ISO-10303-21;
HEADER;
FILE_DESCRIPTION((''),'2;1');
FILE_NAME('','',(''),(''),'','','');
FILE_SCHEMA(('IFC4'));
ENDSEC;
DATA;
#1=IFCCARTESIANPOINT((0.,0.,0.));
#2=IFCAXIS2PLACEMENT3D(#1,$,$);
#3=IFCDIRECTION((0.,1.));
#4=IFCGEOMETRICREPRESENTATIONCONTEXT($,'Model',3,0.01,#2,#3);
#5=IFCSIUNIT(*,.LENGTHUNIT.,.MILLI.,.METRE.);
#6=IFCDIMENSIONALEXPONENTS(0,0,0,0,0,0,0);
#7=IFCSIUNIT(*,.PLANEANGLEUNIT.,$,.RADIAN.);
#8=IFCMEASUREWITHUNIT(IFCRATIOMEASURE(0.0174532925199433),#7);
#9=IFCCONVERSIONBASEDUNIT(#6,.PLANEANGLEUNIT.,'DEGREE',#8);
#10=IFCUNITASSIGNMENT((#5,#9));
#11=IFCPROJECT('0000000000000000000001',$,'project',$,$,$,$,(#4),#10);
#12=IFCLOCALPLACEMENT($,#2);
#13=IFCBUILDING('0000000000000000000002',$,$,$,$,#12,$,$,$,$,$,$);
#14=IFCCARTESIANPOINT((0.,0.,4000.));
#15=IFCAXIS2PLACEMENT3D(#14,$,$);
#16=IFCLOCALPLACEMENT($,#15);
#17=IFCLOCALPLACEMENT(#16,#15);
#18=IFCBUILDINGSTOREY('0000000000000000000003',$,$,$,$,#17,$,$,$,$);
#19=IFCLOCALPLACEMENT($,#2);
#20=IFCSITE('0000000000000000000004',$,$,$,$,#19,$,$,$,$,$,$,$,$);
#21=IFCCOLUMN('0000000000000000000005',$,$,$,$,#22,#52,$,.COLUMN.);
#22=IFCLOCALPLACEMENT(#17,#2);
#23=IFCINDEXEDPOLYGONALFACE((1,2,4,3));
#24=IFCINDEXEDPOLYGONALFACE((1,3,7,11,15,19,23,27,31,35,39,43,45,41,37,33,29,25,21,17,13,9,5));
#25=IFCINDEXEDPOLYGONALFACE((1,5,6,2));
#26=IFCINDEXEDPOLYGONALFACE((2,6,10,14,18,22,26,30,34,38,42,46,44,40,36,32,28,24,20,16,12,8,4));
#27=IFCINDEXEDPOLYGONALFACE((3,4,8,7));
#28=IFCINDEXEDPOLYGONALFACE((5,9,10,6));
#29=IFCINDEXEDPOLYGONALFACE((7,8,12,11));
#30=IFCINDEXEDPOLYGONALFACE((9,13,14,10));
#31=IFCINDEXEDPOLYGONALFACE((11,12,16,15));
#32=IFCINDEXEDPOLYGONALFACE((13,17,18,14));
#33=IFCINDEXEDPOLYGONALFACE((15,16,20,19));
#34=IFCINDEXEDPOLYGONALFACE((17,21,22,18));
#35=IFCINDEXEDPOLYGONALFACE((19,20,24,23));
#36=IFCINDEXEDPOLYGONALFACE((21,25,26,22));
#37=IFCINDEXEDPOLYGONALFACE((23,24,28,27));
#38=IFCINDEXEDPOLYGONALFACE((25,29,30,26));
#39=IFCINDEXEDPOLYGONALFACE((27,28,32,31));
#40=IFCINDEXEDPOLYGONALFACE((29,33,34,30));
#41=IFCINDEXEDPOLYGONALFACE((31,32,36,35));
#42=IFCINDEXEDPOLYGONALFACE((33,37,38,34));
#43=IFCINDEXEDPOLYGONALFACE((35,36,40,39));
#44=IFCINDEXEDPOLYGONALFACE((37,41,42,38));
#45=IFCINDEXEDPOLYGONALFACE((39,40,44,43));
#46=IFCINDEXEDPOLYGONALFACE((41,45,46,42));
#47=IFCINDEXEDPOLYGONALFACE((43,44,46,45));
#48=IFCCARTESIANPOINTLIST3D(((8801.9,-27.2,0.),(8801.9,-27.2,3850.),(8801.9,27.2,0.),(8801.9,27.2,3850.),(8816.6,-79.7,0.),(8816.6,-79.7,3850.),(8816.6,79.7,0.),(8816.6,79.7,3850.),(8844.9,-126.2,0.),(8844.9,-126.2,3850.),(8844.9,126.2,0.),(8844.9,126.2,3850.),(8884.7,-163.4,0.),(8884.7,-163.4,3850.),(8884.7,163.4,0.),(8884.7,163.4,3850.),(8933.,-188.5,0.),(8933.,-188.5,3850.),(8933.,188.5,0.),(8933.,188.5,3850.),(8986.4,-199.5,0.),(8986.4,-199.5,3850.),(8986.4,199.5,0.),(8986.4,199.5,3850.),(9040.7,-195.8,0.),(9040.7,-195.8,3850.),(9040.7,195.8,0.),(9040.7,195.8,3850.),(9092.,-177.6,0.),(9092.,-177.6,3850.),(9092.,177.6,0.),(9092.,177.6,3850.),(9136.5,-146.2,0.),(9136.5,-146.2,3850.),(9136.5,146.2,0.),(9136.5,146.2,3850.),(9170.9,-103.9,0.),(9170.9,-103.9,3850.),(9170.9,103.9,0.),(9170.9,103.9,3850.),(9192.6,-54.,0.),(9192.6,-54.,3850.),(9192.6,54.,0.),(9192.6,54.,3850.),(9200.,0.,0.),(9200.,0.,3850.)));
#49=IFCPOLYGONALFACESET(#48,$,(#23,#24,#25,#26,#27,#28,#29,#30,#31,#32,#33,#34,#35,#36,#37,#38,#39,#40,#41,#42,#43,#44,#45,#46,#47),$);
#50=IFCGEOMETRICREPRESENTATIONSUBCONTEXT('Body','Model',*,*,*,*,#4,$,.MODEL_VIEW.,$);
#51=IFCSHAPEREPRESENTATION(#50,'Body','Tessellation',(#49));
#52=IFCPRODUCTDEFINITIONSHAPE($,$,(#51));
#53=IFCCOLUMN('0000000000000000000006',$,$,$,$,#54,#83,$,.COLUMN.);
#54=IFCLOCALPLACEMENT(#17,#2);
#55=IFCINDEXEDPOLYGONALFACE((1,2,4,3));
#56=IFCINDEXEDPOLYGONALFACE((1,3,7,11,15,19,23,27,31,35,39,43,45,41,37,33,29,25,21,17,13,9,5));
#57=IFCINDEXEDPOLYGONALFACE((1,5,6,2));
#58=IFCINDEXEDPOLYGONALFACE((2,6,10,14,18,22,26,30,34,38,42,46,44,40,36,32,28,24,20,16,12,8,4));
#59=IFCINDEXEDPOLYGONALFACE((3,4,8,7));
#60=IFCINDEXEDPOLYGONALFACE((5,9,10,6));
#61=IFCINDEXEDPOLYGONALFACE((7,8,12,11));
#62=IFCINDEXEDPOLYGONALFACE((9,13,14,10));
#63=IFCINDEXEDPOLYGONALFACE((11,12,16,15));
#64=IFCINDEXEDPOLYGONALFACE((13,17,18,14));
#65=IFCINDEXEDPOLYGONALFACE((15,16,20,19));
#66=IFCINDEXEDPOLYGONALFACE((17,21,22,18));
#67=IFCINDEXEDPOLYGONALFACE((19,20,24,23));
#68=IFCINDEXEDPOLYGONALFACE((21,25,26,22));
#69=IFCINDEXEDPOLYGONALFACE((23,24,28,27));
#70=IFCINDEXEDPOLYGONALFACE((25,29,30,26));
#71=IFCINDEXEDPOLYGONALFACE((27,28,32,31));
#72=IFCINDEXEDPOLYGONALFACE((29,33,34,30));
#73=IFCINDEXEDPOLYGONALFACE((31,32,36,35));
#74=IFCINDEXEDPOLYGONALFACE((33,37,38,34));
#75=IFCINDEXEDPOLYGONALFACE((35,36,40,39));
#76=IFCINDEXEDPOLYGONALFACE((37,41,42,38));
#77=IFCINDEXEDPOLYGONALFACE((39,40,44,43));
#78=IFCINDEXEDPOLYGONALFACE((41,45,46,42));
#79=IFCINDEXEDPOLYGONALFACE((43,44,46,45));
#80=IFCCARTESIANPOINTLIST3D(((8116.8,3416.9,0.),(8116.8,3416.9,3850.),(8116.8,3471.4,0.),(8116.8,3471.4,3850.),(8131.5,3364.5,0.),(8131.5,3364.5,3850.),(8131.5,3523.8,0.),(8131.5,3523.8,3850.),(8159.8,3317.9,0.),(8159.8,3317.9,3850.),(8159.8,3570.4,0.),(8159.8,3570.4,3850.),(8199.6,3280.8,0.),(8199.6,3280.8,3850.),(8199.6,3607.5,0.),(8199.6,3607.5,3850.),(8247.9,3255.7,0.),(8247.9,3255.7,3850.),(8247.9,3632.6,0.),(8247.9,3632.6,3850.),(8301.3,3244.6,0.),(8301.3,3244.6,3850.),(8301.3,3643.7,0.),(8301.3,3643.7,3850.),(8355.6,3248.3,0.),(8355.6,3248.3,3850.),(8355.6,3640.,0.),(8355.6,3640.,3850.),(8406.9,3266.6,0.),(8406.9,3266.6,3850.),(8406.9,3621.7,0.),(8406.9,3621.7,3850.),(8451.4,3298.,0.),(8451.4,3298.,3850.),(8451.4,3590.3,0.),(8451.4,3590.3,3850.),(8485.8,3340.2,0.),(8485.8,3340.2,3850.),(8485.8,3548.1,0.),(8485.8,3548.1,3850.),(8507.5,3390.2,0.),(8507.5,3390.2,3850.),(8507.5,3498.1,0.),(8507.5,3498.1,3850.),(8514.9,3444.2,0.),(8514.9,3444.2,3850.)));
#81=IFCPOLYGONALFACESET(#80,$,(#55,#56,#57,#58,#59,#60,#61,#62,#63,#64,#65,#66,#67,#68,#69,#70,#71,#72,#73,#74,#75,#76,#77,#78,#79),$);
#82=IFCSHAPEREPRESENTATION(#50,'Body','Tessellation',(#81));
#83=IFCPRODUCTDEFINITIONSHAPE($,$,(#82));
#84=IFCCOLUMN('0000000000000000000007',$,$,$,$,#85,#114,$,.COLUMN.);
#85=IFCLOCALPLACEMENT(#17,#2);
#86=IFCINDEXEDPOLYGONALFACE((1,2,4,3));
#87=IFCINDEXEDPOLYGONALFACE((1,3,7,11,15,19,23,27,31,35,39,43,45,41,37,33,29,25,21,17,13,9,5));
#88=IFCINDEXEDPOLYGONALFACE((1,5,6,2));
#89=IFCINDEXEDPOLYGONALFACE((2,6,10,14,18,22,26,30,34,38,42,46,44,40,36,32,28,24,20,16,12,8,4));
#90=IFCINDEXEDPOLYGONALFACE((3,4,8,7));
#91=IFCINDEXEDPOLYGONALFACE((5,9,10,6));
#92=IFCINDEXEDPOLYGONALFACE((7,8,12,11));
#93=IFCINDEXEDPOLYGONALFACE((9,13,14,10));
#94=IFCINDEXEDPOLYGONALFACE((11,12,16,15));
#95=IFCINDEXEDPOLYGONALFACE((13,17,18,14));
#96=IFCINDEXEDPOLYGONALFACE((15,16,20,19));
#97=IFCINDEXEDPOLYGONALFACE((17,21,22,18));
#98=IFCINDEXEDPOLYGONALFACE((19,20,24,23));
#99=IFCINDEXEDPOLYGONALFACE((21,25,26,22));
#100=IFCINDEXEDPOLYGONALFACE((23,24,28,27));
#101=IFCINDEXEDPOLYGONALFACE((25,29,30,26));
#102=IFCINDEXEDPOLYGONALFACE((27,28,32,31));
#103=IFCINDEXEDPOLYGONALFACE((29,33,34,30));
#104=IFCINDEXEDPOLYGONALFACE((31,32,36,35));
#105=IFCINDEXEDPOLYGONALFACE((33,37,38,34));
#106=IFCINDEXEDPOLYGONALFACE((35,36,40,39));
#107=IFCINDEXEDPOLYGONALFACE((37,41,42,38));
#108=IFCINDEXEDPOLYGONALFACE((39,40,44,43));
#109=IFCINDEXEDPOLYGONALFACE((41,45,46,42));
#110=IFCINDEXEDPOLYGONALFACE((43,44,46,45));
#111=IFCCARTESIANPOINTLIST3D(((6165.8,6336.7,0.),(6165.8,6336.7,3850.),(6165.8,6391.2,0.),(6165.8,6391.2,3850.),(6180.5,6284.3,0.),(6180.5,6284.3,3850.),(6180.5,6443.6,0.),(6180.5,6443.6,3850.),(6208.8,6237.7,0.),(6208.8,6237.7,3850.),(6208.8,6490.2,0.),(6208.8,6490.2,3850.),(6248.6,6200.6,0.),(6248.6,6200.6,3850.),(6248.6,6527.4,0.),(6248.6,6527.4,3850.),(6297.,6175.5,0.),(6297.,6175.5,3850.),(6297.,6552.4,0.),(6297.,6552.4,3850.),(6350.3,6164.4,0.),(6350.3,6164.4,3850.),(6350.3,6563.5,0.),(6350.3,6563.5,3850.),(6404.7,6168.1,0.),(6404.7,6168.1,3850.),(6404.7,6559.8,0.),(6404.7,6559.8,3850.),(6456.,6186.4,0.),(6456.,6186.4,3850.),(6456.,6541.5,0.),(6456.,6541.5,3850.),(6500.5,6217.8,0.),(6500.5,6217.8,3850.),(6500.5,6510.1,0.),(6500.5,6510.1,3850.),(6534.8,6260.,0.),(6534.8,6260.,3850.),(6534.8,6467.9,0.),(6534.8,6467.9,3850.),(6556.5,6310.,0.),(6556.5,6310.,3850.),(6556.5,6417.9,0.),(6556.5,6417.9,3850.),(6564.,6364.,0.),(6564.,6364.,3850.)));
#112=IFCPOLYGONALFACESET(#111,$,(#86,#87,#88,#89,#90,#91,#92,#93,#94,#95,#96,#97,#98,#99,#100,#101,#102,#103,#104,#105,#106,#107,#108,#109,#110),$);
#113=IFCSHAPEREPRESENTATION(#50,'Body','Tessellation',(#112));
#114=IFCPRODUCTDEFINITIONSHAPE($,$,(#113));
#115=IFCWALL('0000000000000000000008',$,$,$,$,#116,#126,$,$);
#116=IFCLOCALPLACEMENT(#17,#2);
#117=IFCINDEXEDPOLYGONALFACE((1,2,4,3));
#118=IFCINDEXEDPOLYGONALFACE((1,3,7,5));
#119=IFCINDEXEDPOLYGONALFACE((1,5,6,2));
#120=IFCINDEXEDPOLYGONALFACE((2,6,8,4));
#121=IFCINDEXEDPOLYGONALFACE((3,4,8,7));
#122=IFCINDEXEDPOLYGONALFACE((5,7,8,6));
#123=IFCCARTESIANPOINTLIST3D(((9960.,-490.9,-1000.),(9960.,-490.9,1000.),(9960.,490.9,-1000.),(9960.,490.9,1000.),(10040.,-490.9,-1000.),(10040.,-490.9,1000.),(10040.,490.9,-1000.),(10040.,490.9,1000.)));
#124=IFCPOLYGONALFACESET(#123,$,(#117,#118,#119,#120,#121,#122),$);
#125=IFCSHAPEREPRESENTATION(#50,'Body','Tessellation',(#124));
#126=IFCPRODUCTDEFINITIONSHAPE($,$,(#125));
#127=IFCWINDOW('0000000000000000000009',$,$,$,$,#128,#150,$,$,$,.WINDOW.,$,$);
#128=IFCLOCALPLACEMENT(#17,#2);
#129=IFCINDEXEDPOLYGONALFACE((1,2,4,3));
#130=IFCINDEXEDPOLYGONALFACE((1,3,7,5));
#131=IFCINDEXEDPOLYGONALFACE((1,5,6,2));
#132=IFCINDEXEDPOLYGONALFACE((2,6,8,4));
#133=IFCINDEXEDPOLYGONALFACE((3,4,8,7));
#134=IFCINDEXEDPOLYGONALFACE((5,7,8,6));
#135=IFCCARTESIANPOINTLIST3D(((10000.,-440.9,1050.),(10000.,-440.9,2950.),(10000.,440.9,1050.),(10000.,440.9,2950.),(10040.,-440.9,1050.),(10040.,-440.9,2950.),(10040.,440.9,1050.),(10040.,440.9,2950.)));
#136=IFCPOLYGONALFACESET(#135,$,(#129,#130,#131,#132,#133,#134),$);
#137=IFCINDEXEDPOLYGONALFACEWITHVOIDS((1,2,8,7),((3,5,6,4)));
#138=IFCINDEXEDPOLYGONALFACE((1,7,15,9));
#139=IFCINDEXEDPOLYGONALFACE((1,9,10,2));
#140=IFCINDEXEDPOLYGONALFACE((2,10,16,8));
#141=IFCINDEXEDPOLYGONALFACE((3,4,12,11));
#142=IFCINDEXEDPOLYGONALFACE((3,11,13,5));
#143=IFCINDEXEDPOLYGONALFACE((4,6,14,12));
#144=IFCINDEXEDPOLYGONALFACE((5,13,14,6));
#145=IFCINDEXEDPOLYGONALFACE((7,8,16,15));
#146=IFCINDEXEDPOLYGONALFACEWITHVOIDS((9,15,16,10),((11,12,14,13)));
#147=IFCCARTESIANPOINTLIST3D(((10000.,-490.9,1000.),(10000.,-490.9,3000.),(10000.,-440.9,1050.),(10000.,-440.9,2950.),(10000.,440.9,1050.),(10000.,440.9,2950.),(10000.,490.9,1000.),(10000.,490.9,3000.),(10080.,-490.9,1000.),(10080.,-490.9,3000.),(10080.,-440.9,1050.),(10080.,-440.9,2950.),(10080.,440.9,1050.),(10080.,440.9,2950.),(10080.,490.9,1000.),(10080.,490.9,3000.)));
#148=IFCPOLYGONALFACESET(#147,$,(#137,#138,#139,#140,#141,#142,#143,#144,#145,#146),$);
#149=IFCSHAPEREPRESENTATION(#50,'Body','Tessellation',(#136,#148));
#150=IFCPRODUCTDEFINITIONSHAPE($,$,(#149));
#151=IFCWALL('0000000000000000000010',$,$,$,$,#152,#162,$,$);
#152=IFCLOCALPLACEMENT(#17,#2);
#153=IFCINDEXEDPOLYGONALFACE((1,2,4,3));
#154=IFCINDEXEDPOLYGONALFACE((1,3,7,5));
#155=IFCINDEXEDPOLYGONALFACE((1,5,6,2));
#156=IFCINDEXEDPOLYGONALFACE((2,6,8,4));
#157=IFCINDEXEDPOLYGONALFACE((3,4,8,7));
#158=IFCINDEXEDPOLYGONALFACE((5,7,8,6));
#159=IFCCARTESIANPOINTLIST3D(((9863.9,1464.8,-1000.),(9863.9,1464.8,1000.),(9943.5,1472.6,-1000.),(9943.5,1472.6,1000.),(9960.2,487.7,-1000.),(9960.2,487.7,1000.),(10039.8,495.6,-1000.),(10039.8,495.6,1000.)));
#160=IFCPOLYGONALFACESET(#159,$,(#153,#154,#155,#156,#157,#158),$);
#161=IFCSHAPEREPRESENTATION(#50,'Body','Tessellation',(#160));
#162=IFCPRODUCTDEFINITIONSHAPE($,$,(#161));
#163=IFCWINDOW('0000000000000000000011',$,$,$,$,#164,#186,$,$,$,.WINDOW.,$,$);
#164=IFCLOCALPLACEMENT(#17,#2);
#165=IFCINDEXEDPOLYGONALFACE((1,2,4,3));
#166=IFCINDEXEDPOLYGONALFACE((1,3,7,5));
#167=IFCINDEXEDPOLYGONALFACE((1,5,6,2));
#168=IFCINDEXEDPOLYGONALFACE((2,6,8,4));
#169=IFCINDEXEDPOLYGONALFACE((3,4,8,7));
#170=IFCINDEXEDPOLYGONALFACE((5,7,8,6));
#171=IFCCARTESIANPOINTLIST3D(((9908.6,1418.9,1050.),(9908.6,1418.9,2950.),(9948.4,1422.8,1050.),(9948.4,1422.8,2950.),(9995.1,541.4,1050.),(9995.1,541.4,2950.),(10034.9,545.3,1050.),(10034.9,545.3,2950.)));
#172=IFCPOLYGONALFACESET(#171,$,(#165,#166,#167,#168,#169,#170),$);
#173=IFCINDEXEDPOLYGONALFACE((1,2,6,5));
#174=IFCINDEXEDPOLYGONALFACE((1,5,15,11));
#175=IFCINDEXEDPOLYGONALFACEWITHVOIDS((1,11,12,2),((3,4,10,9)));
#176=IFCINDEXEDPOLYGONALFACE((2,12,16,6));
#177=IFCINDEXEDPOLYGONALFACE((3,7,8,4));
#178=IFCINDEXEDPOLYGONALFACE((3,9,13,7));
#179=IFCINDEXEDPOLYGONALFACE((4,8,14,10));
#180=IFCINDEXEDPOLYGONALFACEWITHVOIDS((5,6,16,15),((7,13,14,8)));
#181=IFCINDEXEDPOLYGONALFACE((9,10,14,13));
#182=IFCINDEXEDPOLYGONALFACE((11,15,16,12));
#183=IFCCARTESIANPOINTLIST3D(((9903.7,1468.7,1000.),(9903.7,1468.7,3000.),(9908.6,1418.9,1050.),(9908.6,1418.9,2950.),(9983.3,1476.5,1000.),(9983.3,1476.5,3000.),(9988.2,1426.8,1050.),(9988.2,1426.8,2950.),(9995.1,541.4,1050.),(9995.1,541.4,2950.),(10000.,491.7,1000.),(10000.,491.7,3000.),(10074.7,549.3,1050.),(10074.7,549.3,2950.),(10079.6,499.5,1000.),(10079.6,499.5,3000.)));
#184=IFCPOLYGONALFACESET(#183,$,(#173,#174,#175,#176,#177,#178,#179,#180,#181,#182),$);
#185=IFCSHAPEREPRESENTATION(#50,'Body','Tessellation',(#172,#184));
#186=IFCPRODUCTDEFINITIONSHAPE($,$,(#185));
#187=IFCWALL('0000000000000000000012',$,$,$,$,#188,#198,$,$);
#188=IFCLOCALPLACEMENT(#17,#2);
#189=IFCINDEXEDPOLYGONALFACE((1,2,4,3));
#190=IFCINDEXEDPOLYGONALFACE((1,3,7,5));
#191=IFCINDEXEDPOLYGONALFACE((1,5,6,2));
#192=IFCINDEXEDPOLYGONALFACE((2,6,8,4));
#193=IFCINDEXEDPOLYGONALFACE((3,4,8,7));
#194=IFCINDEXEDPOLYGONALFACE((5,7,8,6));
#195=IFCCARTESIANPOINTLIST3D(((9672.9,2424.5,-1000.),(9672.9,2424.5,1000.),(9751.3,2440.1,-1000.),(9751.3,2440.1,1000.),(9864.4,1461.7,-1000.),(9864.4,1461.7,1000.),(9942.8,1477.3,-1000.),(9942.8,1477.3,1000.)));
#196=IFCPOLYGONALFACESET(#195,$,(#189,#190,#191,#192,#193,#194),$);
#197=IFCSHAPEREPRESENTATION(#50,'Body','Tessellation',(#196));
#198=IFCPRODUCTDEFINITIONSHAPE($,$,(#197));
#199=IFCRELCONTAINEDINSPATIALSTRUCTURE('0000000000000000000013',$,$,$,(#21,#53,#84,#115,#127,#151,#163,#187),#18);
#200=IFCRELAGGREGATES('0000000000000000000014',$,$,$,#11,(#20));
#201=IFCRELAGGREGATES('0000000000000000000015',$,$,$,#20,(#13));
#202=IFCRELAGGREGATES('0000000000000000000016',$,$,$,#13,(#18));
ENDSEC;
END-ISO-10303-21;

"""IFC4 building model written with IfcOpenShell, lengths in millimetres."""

from ifc_helpers import new_model, entity, si_unit, converted_unit, direction, frame, origin, origin_2d, place, context, subcontext, project, spatial, rectangle, circle, extrude, element, save


model = new_model("IFC4")

# Units and contexts
model_context = context("Model", 3, precision=0.01, world=origin(), true_north=direction((0.0, 1.0)))
body_context = subcontext(model_context, "Body", "Model", "MODEL_VIEW")
ifc_project = project(units=[si_unit("LENGTHUNIT", "METRE", prefix="MILLI"), converted_unit("PLANEANGLEUNIT", "DEGREE", entity("IfcRatioMeasure", 0.0174532925199433), si_unit("PLANEANGLEUNIT", "RADIAN"), dimensions=[0, 0, 0, 0, 0, 0, 0])], contexts=[model_context])

# Site, building, storey
site_placement = place(None, origin())
site = spatial("IfcSite", under=ifc_project, at=site_placement)
building_placement = place(None, origin())
building = spatial("IfcBuilding", under=site, at=building_placement)
placement = place(None, frame((0.0, 0.0, 4000.0)))
storey_placement = place(placement, frame((0.0, 0.0, 4000.0)))
storey = spatial("IfcBuildingStorey", under=building, at=storey_placement)

# Columns
for number, where in (
    (1, (9000.0, 0.0, 0.0)),
    (2, (8314.9, 3444.2, 0.0)),
    (3, (6364.0, 6364.0, 0.0)),
):
    element("IfcColumn", number, at=place(storey_placement, frame(where)), inside=storey, PredefinedType="COLUMN", context=body_context, shape_type="SweptSolid", body=[
        extrude(circle(Radius=200.0, at=origin_2d()), origin(), (0.0, 0.0, 1.0), 3850.0),
    ])

# Wall
wall_1_placement = place(storey_placement, frame((10000.0, 0.0, -1000.0), z_axis=(0.0, 0.0, 1.0), x_axis=(0.0, 10000.0, 0.0)))
element("IfcWall", 4, at=wall_1_placement, inside=storey, context=body_context, shape_type="SweptSolid", body=[
    extrude(rectangle(XDim=981.7, YDim=80.0, at=origin_2d()), origin(), (0.0, 0.0, 1.0), 2000.0),
])

# Window
cartesian_point_1 = entity("IfcCartesianPoint", [-440.9, -950.0])
shared_polyline = entity("IfcPolyline", [cartesian_point_1, entity("IfcCartesianPoint", [-440.9, 950.0]), entity("IfcCartesianPoint", [-440.9, 950.0]), entity("IfcCartesianPoint", [440.9, 950.0]), entity("IfcCartesianPoint", [440.9, 950.0]), entity("IfcCartesianPoint", [440.9, -950.0]), entity("IfcCartesianPoint", [440.9, -950.0]), entity("IfcCartesianPoint", [-440.9, -950.0]), cartesian_point_1])
window_1_placement = place(storey_placement, frame((10000.0, 0.0, 2000.0), z_axis=(0.0, 0.0, 1.0), x_axis=(0.0, 10000.0, 0.0)))
cartesian_point_2 = entity("IfcCartesianPoint", [-490.9, -1000.0])
element("IfcWindow", 5, at=window_1_placement, inside=storey, PredefinedType="WINDOW", context=body_context, shape_type="SweptSolid", body=[
    entity("IfcExtrudedAreaSolid", entity("IfcArbitraryClosedProfileDef", "AREA", None, shared_polyline), entity("IfcAxis2Placement3D", entity("IfcCartesianPoint", [0.0, 0.0, 0.0]), entity("IfcDirection", [0.0, -1.0, 0.0]), entity("IfcDirection", [1.0, 0.0, 0.0])), entity("IfcDirection", [0.0, 0.0, 1.0]), 40.0),
    entity("IfcExtrudedAreaSolid", entity("IfcArbitraryProfileDefWithVoids", "AREA", None, entity("IfcPolyline", [cartesian_point_2, entity("IfcCartesianPoint", [-490.9, 1000.0]), entity("IfcCartesianPoint", [-490.9, 1000.0]), entity("IfcCartesianPoint", [490.9, 1000.0]), entity("IfcCartesianPoint", [490.9, 1000.0]), entity("IfcCartesianPoint", [490.9, -1000.0]), entity("IfcCartesianPoint", [490.9, -1000.0]), entity("IfcCartesianPoint", [-490.9, -1000.0]), cartesian_point_2]), [shared_polyline]), entity("IfcAxis2Placement3D", entity("IfcCartesianPoint", [0.0, 0.0, 0.0]), entity("IfcDirection", [0.0, -1.0, 0.0]), entity("IfcDirection", [1.0, 0.0, 0.0])), entity("IfcDirection", [0.0, 0.0, 1.0]), 80.0),
])

# Wall
wall_2_placement = place(storey_placement, frame((9951.8, 980.2, -1000.0), z_axis=(0.0, 0.0, 1.0), x_axis=(-980.17143, 9951.847264, 0.0)))
element("IfcWall", 6, at=wall_2_placement, inside=storey, context=body_context, shape_type="SweptSolid", body=[
    extrude(rectangle(XDim=981.7, YDim=80.0, at=origin_2d()), origin(), (0.0, 0.0, 1.0), 2000.0),
])

# Window
window_2_placement = place(storey_placement, frame((9951.8, 980.2, 2000.0), z_axis=(0.0, 0.0, 1.0), x_axis=(-980.17143, 9951.847264, 0.0)))
cartesian_point_3 = entity("IfcCartesianPoint", [-490.9, -1000.0])
element("IfcWindow", 7, at=window_2_placement, inside=storey, PredefinedType="WINDOW", context=body_context, shape_type="SweptSolid", body=[
    entity("IfcExtrudedAreaSolid", entity("IfcArbitraryClosedProfileDef", "AREA", None, shared_polyline), entity("IfcAxis2Placement3D", entity("IfcCartesianPoint", [0.0, 0.0, 0.0]), entity("IfcDirection", [0.0, -1.0, 0.0]), entity("IfcDirection", [1.0, 0.0, 0.0])), entity("IfcDirection", [0.0, 0.0, 1.0]), 40.0),
    entity("IfcExtrudedAreaSolid", entity("IfcArbitraryProfileDefWithVoids", "AREA", None, entity("IfcPolyline", [cartesian_point_3, entity("IfcCartesianPoint", [-490.9, 1000.0]), entity("IfcCartesianPoint", [-490.9, 1000.0]), entity("IfcCartesianPoint", [490.9, 1000.0]), entity("IfcCartesianPoint", [490.9, 1000.0]), entity("IfcCartesianPoint", [490.9, -1000.0]), entity("IfcCartesianPoint", [490.9, -1000.0]), entity("IfcCartesianPoint", [-490.9, -1000.0]), cartesian_point_3]), [shared_polyline]), entity("IfcAxis2Placement3D", entity("IfcCartesianPoint", [0.0, 0.0, 0.0]), entity("IfcDirection", [0.0, -1.0, 0.0]), entity("IfcDirection", [1.0, 0.0, 0.0])), entity("IfcDirection", [0.0, 0.0, 1.0]), 80.0),
])

# Wall
wall_3_placement = place(storey_placement, frame((9807.9, 1950.9, -1000.0), z_axis=(0.0, 0.0, 1.0), x_axis=(-1950.903274, 9807.852793, 0.0)))
element("IfcWall", 8, at=wall_3_placement, inside=storey, context=body_context, shape_type="SweptSolid", body=[
    extrude(rectangle(XDim=981.7, YDim=80.0, at=origin_2d()), origin(), (0.0, 0.0, 1.0), 2000.0),
])

save(model, "model.ifc")
